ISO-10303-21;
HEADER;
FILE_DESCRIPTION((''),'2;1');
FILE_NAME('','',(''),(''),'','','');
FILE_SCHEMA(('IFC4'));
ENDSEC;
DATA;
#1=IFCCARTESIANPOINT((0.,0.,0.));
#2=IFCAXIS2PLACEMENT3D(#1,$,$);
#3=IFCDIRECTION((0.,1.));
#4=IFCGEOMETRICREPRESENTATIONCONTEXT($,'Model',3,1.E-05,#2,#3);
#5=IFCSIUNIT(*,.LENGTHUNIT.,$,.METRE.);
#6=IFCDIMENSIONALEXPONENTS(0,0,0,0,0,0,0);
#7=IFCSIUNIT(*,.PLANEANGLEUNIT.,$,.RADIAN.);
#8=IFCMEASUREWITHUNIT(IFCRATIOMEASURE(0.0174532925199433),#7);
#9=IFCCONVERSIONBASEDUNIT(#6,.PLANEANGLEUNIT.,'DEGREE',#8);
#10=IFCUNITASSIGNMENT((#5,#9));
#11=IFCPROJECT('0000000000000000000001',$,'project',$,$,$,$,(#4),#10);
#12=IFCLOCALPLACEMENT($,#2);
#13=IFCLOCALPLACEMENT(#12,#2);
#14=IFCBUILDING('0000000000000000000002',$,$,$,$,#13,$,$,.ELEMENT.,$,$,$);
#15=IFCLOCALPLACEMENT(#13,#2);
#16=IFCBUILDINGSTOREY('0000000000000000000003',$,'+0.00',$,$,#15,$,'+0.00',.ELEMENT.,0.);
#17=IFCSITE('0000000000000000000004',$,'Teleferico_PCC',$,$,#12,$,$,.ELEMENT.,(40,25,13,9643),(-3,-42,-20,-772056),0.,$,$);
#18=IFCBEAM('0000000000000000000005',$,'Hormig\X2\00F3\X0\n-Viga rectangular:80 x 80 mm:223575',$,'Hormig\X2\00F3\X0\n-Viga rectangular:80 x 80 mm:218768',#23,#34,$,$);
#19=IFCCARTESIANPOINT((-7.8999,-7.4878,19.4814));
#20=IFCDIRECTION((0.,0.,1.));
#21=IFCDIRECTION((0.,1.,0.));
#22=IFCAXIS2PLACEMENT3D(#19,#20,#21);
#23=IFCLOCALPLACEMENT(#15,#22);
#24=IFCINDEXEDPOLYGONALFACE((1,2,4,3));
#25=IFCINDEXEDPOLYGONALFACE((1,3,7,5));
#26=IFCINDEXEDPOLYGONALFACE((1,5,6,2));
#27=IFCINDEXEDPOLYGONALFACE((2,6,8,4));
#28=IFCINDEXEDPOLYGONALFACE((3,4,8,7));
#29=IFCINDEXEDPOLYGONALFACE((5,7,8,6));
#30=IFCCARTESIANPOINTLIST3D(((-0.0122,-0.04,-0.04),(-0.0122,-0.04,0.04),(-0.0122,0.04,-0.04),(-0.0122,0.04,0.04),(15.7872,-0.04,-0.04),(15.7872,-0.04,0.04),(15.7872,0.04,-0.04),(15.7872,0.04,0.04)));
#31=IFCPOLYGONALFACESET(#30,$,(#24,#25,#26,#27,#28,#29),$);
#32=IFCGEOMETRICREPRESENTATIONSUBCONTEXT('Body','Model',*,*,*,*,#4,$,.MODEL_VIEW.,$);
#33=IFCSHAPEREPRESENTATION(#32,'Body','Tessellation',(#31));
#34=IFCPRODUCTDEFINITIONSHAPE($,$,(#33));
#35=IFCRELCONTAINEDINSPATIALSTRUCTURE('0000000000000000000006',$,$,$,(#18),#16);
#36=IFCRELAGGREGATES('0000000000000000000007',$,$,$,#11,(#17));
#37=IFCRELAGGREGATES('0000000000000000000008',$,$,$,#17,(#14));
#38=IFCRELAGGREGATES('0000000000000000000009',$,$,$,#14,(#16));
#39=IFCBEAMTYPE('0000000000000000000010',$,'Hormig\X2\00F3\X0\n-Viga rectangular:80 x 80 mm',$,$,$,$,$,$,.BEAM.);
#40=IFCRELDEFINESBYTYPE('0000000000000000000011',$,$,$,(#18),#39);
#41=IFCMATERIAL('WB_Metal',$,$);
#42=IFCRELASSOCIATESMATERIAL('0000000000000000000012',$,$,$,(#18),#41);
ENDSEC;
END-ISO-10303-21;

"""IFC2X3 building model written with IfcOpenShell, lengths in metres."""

from ifc_helpers import new_model, entity, si_unit, converted_unit, direction, frame, frame_2d, origin, place, context, subcontext, project, spatial, rectangle, extrude, material, type_object, element, save


model = new_model("IFC2X3")

# Units and contexts
model_context = context("Model", 3, precision=1e-05, world=origin(), true_north=direction((0.0, 1.0)))
body_context = subcontext(model_context, "Body", "Model", "MODEL_VIEW")
ifc_project = project(units=[si_unit("LENGTHUNIT", "METRE"), converted_unit("PLANEANGLEUNIT", "DEGREE", entity("IfcRatioMeasure", 0.0174532925199433), si_unit("PLANEANGLEUNIT", "RADIAN"), dimensions=[0, 0, 0, 0, 0, 0, 0])], contexts=[model_context])

# Site, building, storey
site_placement = place(None, origin())
site = spatial("IfcSite", under=ifc_project, at=site_placement, Name="Teleferico_PCC", CompositionType="ELEMENT", RefLatitude=(40, 25, 13, 9643), RefLongitude=(-3, -42, -20, -772056), RefElevation=0.0)
building_placement = place(site_placement, origin())
building = spatial("IfcBuilding", under=site, at=building_placement, CompositionType="ELEMENT")
storey_placement = place(building_placement, origin())
storey = spatial("IfcBuildingStorey", under=building, at=storey_placement, Name="+0.00", LongName="+0.00", CompositionType="ELEMENT", Elevation=0.0)

# Shared definitions
ifc_material = material(Name="WB_Metal")

# Beam
beam_type = type_object("IfcBeamType", Name="Hormigón-Viga rectangular:80 x 80 mm", PredefinedType="BEAM")
beam_1_placement = place(storey_placement, frame((-7.8999, -7.4878, 19.4814), z_axis=(0.0, 0.0, 1.0), x_axis=(0.0, 1.0, 0.0)))
element("IfcBeam", 1, at=beam_1_placement, inside=storey, type_object=beam_type, material=ifc_material, Name="Hormigón-Viga rectangular:80 x 80 mm:223575", ObjectType="Hormigón-Viga rectangular:80 x 80 mm:218768", context=body_context, shape_type="SweptSolid", body=[
    extrude(rectangle(XDim=0.08, YDim=0.08, at=frame_2d((0.0, 0.0), x_axis=(1.0, 0.0))), frame((-0.0122, 0.0, 0.0), z_axis=(1.0, 0.0, 0.0), x_axis=(0.0, 0.0, -1.0)), (0.0, 0.0, 1.0), 15.7994),
])

save(model, "model.ifc")
